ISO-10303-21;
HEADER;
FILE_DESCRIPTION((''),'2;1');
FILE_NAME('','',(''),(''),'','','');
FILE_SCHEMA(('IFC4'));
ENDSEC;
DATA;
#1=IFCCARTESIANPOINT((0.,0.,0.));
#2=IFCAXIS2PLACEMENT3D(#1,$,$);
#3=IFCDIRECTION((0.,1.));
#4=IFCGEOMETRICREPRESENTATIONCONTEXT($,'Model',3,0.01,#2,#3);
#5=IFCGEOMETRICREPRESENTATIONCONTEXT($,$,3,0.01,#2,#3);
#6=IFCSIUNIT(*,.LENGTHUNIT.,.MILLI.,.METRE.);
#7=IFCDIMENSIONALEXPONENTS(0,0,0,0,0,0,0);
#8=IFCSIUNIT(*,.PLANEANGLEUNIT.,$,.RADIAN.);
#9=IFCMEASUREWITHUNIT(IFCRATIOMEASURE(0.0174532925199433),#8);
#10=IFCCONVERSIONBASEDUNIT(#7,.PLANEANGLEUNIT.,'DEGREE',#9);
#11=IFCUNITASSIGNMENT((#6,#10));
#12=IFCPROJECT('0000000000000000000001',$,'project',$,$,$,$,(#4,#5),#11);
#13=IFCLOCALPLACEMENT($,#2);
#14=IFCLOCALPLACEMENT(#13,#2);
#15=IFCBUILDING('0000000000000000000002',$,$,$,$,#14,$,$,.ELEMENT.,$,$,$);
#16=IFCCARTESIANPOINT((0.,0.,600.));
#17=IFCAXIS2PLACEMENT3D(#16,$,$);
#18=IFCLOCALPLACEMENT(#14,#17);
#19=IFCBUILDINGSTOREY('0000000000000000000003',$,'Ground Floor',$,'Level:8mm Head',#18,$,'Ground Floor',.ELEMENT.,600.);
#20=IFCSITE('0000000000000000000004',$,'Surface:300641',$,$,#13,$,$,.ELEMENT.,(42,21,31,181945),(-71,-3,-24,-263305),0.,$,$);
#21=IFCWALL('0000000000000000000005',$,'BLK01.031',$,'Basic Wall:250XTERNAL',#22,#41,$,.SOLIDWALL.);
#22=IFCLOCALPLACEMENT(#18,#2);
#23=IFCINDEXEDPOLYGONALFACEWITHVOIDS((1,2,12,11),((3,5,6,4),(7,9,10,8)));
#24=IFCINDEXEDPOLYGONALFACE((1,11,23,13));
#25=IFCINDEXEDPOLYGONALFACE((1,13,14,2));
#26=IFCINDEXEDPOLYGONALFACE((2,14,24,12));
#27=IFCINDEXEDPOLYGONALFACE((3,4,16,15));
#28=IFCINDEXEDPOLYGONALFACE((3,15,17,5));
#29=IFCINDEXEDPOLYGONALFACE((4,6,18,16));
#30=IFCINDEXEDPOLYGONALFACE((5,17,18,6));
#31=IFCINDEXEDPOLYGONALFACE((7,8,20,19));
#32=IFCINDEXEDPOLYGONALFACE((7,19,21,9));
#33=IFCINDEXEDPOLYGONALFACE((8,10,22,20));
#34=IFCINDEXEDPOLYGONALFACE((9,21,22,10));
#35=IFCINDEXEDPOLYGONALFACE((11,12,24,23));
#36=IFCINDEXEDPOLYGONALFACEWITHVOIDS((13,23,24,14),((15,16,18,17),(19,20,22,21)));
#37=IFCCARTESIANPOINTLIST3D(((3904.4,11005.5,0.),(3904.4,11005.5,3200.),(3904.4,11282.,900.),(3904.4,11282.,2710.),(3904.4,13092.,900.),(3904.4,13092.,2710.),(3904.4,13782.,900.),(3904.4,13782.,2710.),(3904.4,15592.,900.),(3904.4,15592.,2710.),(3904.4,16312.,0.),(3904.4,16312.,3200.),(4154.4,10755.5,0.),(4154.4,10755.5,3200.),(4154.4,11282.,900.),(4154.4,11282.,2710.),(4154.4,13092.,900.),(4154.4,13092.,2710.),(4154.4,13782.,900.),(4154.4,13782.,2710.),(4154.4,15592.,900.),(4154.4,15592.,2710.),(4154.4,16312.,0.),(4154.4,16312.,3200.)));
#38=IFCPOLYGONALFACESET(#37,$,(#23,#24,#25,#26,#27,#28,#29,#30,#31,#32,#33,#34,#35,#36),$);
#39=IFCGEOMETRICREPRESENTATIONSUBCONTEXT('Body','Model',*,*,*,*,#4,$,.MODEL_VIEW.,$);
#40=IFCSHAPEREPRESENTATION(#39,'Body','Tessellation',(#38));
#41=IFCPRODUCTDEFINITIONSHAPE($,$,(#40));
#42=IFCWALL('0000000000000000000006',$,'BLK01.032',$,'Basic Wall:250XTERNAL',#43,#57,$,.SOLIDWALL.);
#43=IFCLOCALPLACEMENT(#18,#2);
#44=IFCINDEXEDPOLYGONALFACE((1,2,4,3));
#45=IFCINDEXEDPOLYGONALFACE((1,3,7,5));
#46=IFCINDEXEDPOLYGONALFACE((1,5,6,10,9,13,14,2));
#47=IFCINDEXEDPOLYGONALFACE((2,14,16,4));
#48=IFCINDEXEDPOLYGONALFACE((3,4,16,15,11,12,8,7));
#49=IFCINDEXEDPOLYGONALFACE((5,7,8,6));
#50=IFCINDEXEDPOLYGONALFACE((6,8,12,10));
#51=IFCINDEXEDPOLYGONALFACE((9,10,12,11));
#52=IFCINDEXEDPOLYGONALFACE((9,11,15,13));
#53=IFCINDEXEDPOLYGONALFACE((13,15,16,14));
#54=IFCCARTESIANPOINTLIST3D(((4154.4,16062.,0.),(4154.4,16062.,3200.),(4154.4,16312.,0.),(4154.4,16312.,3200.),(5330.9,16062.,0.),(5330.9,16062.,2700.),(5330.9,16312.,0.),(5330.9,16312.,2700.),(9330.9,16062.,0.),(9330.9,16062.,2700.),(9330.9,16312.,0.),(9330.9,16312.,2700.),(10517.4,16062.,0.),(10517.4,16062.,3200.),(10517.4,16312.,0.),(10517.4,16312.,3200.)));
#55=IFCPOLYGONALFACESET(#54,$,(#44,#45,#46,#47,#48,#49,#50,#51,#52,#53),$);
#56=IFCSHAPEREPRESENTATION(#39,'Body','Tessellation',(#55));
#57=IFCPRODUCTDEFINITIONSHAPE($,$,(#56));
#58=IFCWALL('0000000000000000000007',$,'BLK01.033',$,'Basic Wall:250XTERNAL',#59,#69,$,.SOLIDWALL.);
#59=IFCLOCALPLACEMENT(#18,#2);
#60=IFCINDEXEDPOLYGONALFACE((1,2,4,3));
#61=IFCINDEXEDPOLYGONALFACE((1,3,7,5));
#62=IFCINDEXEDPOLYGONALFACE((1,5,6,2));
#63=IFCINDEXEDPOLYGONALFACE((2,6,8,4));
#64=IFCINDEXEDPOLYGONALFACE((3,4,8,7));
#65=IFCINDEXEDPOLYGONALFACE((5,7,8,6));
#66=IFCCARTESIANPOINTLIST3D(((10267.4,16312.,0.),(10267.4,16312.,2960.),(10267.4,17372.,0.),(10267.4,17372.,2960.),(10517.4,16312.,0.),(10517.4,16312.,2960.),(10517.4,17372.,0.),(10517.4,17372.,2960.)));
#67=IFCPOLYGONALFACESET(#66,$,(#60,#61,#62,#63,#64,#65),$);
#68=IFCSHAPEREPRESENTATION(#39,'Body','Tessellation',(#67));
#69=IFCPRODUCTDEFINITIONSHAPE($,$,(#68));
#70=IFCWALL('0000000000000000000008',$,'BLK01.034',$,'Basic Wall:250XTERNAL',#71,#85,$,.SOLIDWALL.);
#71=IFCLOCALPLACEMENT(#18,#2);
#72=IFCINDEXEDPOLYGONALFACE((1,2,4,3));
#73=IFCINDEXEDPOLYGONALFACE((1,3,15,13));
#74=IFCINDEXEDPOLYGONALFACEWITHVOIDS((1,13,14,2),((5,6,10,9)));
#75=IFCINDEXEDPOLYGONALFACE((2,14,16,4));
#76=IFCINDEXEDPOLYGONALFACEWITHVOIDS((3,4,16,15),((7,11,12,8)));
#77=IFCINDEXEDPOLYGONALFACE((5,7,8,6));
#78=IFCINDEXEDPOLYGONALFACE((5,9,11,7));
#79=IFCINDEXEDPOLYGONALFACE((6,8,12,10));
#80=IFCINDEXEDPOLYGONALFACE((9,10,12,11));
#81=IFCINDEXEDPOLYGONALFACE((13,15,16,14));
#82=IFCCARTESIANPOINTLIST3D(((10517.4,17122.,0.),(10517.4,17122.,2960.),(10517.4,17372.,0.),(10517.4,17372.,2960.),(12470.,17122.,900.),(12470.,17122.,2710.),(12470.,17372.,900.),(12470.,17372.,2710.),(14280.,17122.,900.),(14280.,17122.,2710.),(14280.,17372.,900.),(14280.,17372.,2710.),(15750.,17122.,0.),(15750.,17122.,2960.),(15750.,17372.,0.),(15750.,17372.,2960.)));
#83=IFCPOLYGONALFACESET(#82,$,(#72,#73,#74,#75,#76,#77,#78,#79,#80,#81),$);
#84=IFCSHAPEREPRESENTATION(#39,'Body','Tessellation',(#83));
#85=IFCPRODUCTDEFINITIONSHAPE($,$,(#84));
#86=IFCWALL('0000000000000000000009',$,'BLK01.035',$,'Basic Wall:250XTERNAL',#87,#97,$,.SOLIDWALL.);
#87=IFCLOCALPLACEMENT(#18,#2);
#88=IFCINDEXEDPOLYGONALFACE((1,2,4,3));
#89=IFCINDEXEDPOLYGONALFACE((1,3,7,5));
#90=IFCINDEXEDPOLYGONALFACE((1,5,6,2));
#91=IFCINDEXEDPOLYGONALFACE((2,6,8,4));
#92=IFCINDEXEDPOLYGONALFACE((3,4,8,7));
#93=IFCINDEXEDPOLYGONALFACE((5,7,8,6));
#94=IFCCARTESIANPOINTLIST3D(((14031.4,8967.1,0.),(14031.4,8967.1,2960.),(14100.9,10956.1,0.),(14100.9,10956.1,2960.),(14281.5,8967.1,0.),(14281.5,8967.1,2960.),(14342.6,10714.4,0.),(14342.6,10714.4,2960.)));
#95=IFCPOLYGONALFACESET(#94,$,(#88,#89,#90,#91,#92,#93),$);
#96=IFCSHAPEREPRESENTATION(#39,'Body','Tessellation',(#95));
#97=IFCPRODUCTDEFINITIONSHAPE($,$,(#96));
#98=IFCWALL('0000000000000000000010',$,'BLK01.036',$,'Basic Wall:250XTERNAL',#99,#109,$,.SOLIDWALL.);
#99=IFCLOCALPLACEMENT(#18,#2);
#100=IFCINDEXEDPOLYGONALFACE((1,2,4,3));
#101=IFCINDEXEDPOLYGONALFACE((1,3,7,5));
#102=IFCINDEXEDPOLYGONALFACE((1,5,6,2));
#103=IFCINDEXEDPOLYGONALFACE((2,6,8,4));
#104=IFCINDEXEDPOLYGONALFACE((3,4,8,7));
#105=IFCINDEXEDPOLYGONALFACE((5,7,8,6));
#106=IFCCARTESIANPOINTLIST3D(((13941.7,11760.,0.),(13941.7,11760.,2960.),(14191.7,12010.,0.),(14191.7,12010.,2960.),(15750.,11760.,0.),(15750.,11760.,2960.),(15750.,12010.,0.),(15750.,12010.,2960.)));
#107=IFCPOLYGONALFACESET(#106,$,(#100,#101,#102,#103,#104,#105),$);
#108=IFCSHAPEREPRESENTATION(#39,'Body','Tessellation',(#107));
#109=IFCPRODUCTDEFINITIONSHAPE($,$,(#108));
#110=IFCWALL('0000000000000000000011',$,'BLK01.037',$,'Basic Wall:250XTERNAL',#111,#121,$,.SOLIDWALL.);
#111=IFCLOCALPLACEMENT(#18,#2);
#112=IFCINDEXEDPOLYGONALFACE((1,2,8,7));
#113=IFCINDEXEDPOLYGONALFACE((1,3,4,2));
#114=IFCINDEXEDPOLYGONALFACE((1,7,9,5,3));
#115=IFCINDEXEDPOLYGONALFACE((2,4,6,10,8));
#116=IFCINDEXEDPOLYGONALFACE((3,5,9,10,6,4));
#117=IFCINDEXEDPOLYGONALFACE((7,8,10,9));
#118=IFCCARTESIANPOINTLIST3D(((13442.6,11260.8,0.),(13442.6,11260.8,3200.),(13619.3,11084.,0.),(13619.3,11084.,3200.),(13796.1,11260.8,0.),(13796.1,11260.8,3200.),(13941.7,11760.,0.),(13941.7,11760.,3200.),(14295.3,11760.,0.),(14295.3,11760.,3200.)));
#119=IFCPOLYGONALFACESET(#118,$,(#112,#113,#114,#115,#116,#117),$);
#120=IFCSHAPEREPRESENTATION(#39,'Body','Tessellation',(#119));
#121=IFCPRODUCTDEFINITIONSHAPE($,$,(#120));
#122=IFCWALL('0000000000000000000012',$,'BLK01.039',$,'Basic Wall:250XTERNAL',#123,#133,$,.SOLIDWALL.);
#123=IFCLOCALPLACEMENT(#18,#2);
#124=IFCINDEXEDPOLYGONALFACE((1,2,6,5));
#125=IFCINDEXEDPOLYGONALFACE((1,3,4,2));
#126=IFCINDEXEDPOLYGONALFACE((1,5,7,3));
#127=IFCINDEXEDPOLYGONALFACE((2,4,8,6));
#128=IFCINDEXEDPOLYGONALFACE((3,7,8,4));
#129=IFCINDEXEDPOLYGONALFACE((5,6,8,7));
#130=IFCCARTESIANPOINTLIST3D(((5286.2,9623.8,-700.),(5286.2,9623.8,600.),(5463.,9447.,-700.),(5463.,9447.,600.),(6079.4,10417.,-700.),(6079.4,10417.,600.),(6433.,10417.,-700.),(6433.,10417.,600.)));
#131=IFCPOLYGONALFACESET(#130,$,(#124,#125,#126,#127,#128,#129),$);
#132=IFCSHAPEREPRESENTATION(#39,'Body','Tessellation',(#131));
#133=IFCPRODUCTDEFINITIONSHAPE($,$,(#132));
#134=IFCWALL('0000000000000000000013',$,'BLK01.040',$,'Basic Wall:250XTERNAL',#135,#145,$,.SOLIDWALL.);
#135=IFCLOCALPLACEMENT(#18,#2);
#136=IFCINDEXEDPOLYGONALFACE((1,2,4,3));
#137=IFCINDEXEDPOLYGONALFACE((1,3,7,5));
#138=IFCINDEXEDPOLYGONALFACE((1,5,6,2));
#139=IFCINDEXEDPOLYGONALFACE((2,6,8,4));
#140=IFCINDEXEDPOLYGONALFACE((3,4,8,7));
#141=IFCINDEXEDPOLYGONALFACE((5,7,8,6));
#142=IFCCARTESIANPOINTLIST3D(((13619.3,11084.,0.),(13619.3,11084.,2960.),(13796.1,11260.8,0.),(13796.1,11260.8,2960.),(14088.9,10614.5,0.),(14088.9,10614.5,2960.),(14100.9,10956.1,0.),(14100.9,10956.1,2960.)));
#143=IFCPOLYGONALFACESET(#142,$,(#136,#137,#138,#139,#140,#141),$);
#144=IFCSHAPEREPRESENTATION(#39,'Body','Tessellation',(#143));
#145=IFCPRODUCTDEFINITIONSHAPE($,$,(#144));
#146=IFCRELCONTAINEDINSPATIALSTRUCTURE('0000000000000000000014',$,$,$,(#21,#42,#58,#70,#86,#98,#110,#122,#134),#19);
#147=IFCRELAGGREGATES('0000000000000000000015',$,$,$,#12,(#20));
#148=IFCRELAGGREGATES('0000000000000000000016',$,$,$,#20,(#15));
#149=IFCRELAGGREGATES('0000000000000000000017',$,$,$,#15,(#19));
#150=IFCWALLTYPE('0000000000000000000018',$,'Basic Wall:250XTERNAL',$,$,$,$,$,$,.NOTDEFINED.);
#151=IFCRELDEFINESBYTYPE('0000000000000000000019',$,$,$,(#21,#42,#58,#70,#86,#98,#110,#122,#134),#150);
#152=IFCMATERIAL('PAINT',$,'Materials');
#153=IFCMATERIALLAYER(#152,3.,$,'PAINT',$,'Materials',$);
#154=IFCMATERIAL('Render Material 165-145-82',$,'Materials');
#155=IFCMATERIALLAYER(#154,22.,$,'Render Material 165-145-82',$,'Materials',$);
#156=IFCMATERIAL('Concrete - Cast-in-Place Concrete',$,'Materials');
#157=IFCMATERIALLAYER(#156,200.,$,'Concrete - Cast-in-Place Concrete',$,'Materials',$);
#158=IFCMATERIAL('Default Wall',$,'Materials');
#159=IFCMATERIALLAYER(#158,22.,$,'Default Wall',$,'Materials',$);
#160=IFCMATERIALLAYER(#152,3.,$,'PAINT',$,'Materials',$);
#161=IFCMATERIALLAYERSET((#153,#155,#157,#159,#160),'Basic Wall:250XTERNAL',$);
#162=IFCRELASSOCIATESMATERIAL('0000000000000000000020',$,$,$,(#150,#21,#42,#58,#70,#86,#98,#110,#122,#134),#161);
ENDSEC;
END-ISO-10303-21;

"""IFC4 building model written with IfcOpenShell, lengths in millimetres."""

from ifc_helpers import new_model, entity, si_unit, converted_unit, direction, frame, frame_2d, origin, place, context, subcontext, project, spatial, polyline, rectangle, outline, extrude, clip, halfspace, bounded_halfspace, material, layer, layer_set, layer_usage, type_object, element, save


model = new_model("IFC4")

# Units and contexts
model_context = context("Model", 3, precision=0.01, world=origin(), true_north=direction((0.0, 1.0)))
context_of_model = context(None, 3, precision=0.01, world=origin(), true_north=direction((0.0, 1.0)))
body_context = subcontext(model_context, "Body", "Model", "MODEL_VIEW")
ifc_project = project(units=[si_unit("LENGTHUNIT", "METRE", prefix="MILLI"), converted_unit("PLANEANGLEUNIT", "DEGREE", entity("IfcRatioMeasure", 0.0174532925199433), si_unit("PLANEANGLEUNIT", "RADIAN"), dimensions=[0, 0, 0, 0, 0, 0, 0])], contexts=[model_context, context_of_model])

# Site, building, storey
site_placement = place(None, origin())
site = spatial("IfcSite", under=ifc_project, at=site_placement, Name="Surface:300641", CompositionType="ELEMENT", RefLatitude=(42, 21, 31, 181945), RefLongitude=(-71, -3, -24, -263305), RefElevation=0.0)
building_placement = place(site_placement, origin())
building = spatial("IfcBuilding", under=site, at=building_placement, CompositionType="ELEMENT")
storey_placement = place(building_placement, frame((0.0, 0.0, 600.0)))
storey = spatial("IfcBuildingStorey", under=building, at=storey_placement, Name="Ground Floor", ObjectType="Level:8mm Head", LongName="Ground Floor", CompositionType="ELEMENT", Elevation=600.0)

# Shared definitions
ifc_material_1 = material(Name="PAINT", Category="Materials")
ifc_layer_1 = layer(ifc_material_1, 3.0, Name="PAINT", Category="Materials")
ifc_material_2 = material(Name="Render Material 165-145-82", Category="Materials")
ifc_layer_2 = layer(ifc_material_2, 22.0, Name="Render Material 165-145-82", Category="Materials")
ifc_material_3 = material(Name="Concrete - Cast-in-Place Concrete", Category="Materials")
ifc_layer_3 = layer(ifc_material_3, 200.0, Name="Concrete - Cast-in-Place Concrete", Category="Materials")
ifc_material_4 = material(Name="Default Wall", Category="Materials")
ifc_layer_4 = layer(ifc_material_4, 22.0, Name="Default Wall", Category="Materials")
ifc_layer_5 = layer(ifc_material_1, 3.0, Name="PAINT", Category="Materials")
ifc_layer_set_1 = layer_set([ifc_layer_1, ifc_layer_2, ifc_layer_3, ifc_layer_4, ifc_layer_5], Name="Basic Wall:250XTERNAL")
wall_type_1 = type_object("IfcWallType", Name="Basic Wall:250XTERNAL", PredefinedType="NOTDEFINED", material=ifc_layer_set_1)

# Wall, openings
ifc_layer_usage_1 = layer_usage(ifc_layer_set_1, "AXIS2", "NEGATIVE", 125.0)
wall_1_placement = place(storey_placement, frame((4029.4, 10755.5, 0.0), z_axis=(0.0, 0.0, 1.0), x_axis=(0.0, 1.0, 0.0)))
wall_1 = element("IfcWall", 1, at=wall_1_placement, inside=storey, type_object=wall_type_1, material=ifc_layer_usage_1, Name="BLK01.031", ObjectType="Basic Wall:250XTERNAL", PredefinedType="SOLIDWALL", context=body_context, shape_type="Clipping", body=[
    clip(extrude(outline(polyline([(5556.5, -125.0), (5556.5, 125.0), (250.0, 125.0), (0.0, -125.0), (5306.5, -125.0), (5556.5, -125.0)])), origin(), (0.0, 0.0, 1.0), 3200.0), halfspace(origin(), True)),
])
opening_1_placement = place(wall_1_placement, frame((526.5, -125.0, 900.0)))
element("IfcOpeningElement", 2, at=opening_1_placement, cuts=wall_1, ObjectType="Opening", PredefinedType="OPENING", context=body_context, shape_type="SweptSolid", body=[
    extrude(rectangle(XDim=1810.0, YDim=1810.0, at=frame_2d((905.0, 905.0), x_axis=(-1.0, 0.0))), frame((0.0, 0.0, 0.0), z_axis=(0.0, 1.0, 0.0), x_axis=(0.0, 0.0, 1.0)), (0.0, 0.0, 1.0), 250.0),
])
opening_2_placement = place(wall_1_placement, frame((3026.5, -125.0, 900.0)))
element("IfcOpeningElement", 3, at=opening_2_placement, cuts=wall_1, ObjectType="Opening", PredefinedType="OPENING", context=body_context, shape_type="SweptSolid", body=[
    extrude(rectangle(XDim=1810.0, YDim=1810.0, at=frame_2d((905.0, 905.0), x_axis=(-1.0, 0.0))), frame((0.0, 0.0, 0.0), z_axis=(0.0, 1.0, 0.0), x_axis=(0.0, 0.0, 1.0)), (0.0, 0.0, 1.0), 250.0),
])

# Wall, opening
ifc_layer_usage_2 = layer_usage(ifc_layer_set_1, "AXIS2", "NEGATIVE", 125.0)
wall_2_placement = place(storey_placement, frame((4154.4, 16187.0, 0.0)))
wall_2 = element("IfcWall", 4, at=wall_2_placement, inside=storey, type_object=wall_type_1, material=ifc_layer_usage_2, Name="BLK01.032", ObjectType="Basic Wall:250XTERNAL", PredefinedType="SOLIDWALL", context=body_context, shape_type="Clipping", body=[
    clip(extrude(rectangle(XDim=6362.9, YDim=250.0, at=frame_2d((3181.5, 0.0), x_axis=(-1.0, 0.0))), origin(), (0.0, 0.0, 1.0), 3200.0), halfspace(origin(), True)),
])
opening_3_placement = place(wall_2_placement, frame((5176.5, 125.0, 0.0)))
element("IfcOpeningElement", 5, at=opening_3_placement, cuts=wall_2, ObjectType="Opening", PredefinedType="OPENING", context=body_context, shape_type="SweptSolid", body=[
    extrude(rectangle(XDim=2700.0, YDim=4000.0, at=frame_2d((1350.0, 2000.0), x_axis=(-1.0, 0.0))), frame((0.0, 0.0, 0.0), z_axis=(0.0, -1.0, 0.0), x_axis=(0.0, 0.0, 1.0)), (0.0, 0.0, 1.0), 250.0),
])

# Wall
ifc_layer_usage_3 = layer_usage(ifc_layer_set_1, "AXIS2", "NEGATIVE", 125.0)
wall_3_placement = place(storey_placement, frame((10392.4, 16312.0, 0.0), z_axis=(0.0, 0.0, 1.0), x_axis=(0.0, 1.0, 0.0)))
element("IfcWall", 6, at=wall_3_placement, inside=storey, type_object=wall_type_1, material=ifc_layer_usage_3, Name="BLK01.033", ObjectType="Basic Wall:250XTERNAL", PredefinedType="SOLIDWALL", context=body_context, shape_type="Clipping", body=[
    clip(extrude(rectangle(XDim=1060.0, YDim=250.0, at=frame_2d((530.0, 0.0), x_axis=(-1.0, 0.0))), origin(), (0.0, 0.0, 1.0), 2960.0), bounded_halfspace(frame((0.0, -125.0, 2960.0), z_axis=(0.0, 0.0, -1.0), x_axis=(-1.0, 0.0, 0.0)), True, frame((0.0, -125.0, 2960.0)), polyline([(0.0, 0.0), (810.0, 0.0), (1060.0, 0.0), (1060.0, 250.0), (0.0, 250.0), (0.0, 0.0)]))),
])

# Wall, opening
ifc_layer_usage_4 = layer_usage(ifc_layer_set_1, "AXIS2", "NEGATIVE", 125.0)
wall_4_placement = place(storey_placement, frame((10517.4, 17247.0, 0.0)))
wall_4 = element("IfcWall", 7, at=wall_4_placement, inside=storey, type_object=wall_type_1, material=ifc_layer_usage_4, Name="BLK01.034", ObjectType="Basic Wall:250XTERNAL", PredefinedType="SOLIDWALL", context=body_context, shape_type="Clipping", body=[
    clip(extrude(rectangle(XDim=5232.6, YDim=250.0, at=frame_2d((2616.3, 0.0), x_axis=(-1.0, 0.0))), origin(), (0.0, 0.0, 1.0), 2960.0), bounded_halfspace(frame((0.0, -125.0, 2960.0), z_axis=(0.0, 0.0, -1.0), x_axis=(0.0, -1.0, 0.0)), True, frame((0.0, -125.0, 2960.0)), polyline([(0.0, 0.0), (5232.6, 0.0), (5232.6, 250.0), (0.0, 250.0), (0.0, 0.0)]))),
])
opening_4_placement = place(wall_4_placement, frame((1952.6, -125.0, 900.0)))
element("IfcOpeningElement", 8, at=opening_4_placement, cuts=wall_4, ObjectType="Opening", PredefinedType="OPENING", context=body_context, shape_type="SweptSolid", body=[
    extrude(rectangle(XDim=1810.0, YDim=1810.0, at=frame_2d((905.0, 905.0), x_axis=(-1.0, 0.0))), frame((0.0, 0.0, 0.0), z_axis=(0.0, 1.0, 0.0), x_axis=(0.0, 0.0, 1.0)), (0.0, 0.0, 1.0), 250.0),
])

# Walls
ifc_layer_usage_5 = layer_usage(ifc_layer_set_1, "AXIS2", "NEGATIVE", 125.0)
wall_5_placement = place(storey_placement, frame((14156.3, 8962.8, 0.0), z_axis=(0.0, 0.0, 1.0), x_axis=(0.034899, 0.999391, 0.0)))
element("IfcWall", 9, at=wall_5_placement, inside=storey, type_object=wall_type_1, material=ifc_layer_usage_5, Name="BLK01.035", ObjectType="Basic Wall:250XTERNAL", PredefinedType="SOLIDWALL", context=body_context, shape_type="Clipping", body=[
    clip(clip(extrude(outline(polyline([(1757.0, -125.0), (1990.2, 125.0), (1648.3, 125.0), (0.0, 125.0), (8.7, -125.0), (1757.0, -125.0)])), origin(), (0.0, 0.0, 1.0), 2960.0), bounded_halfspace(frame((8.7, -125.0, 2960.0), z_axis=(0.0, 0.0, -1.0), x_axis=(-0.999391, -0.034899, 0.0)), True, frame((8.7, -125.0, 2960.0)), polyline([(0.0, 0.0), (1748.3, 0.0), (1981.4, 250.0), (1639.6, 250.0), (-8.7, 250.0), (0.0, 0.0)]))), halfspace(origin(), True)),
])
ifc_layer_usage_6 = layer_usage(ifc_layer_set_1, "AXIS2", "NEGATIVE", 125.0)
wall_6_placement = place(storey_placement, frame((13941.7, 11885.0, 0.0)))
element("IfcWall", 10, at=wall_6_placement, inside=storey, type_object=wall_type_1, material=ifc_layer_usage_6, Name="BLK01.036", ObjectType="Basic Wall:250XTERNAL", PredefinedType="SOLIDWALL", context=body_context, shape_type="Clipping", body=[
    clip(clip(extrude(outline(polyline([(1808.3, -125.0), (1808.3, 125.0), (250.0, 125.0), (0.0, -125.0), (353.6, -125.0), (1808.3, -125.0)])), origin(), (0.0, 0.0, 1.0), 2960.0), bounded_halfspace(frame((0.0, -125.0, 2960.0), z_axis=(0.0, 0.0, -1.0), x_axis=(0.0, -1.0, 0.0)), True, frame((0.0, -125.0, 2960.0)), polyline([(0.0, 0.0), (1808.3, 0.0), (1808.3, 250.0), (250.0, 250.0), (0.0, 0.0)]))), halfspace(origin(), True)),
])
ifc_layer_usage_7 = layer_usage(ifc_layer_set_1, "AXIS2", "NEGATIVE", 125.0)
wall_7_placement = place(storey_placement, frame((14206.9, 11848.4, 0.0), z_axis=(0.0, 0.0, 1.0), x_axis=(-0.707107, -0.707107, 0.0)))
element("IfcWall", 11, at=wall_7_placement, inside=storey, type_object=wall_type_1, material=ifc_layer_usage_7, Name="BLK01.037", ObjectType="Basic Wall:250XTERNAL", PredefinedType="SOLIDWALL", context=body_context, shape_type="SweptSolid", body=[
    extrude(outline(polyline([(955.9, -125.0), (955.9, 125.0), (705.9, 125.0), (0.0, 125.0), (250.0, -125.0), (955.9, -125.0)])), origin(), (0.0, 0.0, 1.0), 3200.0),
])
ifc_layer_usage_8 = layer_usage(ifc_layer_set_1, "AXIS2", "POSITIVE", -125.0)
wall_8_placement = place(storey_placement, frame((5286.2, 9447.0, -700.0), z_axis=(0.0, 0.0, 1.0), x_axis=(0.707107, 0.707107, 0.0)))
element("IfcWall", 12, at=wall_8_placement, inside=storey, type_object=wall_type_1, material=ifc_layer_usage_8, Name="BLK01.039", ObjectType="Basic Wall:250XTERNAL", PredefinedType="SOLIDWALL", context=body_context, shape_type="SweptSolid", body=[
    extrude(outline(polyline([(1496.8, -125.0), (1246.8, 125.0), (125.0, 125.0), (125.0, -125.0), (1496.8, -125.0)])), origin(), (0.0, 0.0, 1.0), 1300.0),
])
ifc_layer_usage_9 = layer_usage(ifc_layer_set_1, "AXIS2", "POSITIVE", -125.0)
wall_9_placement = place(storey_placement, frame((14177.3, 10702.9, 0.0), z_axis=(0.0, 0.0, 1.0), x_axis=(-0.707107, 0.707107, 0.0)))
element("IfcWall", 13, at=wall_9_placement, inside=storey, type_object=wall_type_1, material=ifc_layer_usage_9, Name="BLK01.040", ObjectType="Basic Wall:250XTERNAL", PredefinedType="SOLIDWALL", context=body_context, shape_type="Clipping", body=[
    clip(clip(extrude(outline(polyline([(664.1, -125.0), (664.1, 125.0), (0.0, 125.0), (233.1, -125.0), (664.1, -125.0)])), origin(), (0.0, 0.0, 1.0), 2960.0), bounded_halfspace(frame((233.1, -125.0, 2960.0), z_axis=(0.0, 0.0, -1.0), x_axis=(-0.707107, 0.707107, 0.0)), True, frame((233.1, -125.0, 2960.0)), polyline([(0.0, 0.0), (431.0, 0.0), (431.0, 250.0), (-233.1, 250.0), (0.0, 0.0)]))), halfspace(origin(), True)),
])

save(model, "model.ifc")
